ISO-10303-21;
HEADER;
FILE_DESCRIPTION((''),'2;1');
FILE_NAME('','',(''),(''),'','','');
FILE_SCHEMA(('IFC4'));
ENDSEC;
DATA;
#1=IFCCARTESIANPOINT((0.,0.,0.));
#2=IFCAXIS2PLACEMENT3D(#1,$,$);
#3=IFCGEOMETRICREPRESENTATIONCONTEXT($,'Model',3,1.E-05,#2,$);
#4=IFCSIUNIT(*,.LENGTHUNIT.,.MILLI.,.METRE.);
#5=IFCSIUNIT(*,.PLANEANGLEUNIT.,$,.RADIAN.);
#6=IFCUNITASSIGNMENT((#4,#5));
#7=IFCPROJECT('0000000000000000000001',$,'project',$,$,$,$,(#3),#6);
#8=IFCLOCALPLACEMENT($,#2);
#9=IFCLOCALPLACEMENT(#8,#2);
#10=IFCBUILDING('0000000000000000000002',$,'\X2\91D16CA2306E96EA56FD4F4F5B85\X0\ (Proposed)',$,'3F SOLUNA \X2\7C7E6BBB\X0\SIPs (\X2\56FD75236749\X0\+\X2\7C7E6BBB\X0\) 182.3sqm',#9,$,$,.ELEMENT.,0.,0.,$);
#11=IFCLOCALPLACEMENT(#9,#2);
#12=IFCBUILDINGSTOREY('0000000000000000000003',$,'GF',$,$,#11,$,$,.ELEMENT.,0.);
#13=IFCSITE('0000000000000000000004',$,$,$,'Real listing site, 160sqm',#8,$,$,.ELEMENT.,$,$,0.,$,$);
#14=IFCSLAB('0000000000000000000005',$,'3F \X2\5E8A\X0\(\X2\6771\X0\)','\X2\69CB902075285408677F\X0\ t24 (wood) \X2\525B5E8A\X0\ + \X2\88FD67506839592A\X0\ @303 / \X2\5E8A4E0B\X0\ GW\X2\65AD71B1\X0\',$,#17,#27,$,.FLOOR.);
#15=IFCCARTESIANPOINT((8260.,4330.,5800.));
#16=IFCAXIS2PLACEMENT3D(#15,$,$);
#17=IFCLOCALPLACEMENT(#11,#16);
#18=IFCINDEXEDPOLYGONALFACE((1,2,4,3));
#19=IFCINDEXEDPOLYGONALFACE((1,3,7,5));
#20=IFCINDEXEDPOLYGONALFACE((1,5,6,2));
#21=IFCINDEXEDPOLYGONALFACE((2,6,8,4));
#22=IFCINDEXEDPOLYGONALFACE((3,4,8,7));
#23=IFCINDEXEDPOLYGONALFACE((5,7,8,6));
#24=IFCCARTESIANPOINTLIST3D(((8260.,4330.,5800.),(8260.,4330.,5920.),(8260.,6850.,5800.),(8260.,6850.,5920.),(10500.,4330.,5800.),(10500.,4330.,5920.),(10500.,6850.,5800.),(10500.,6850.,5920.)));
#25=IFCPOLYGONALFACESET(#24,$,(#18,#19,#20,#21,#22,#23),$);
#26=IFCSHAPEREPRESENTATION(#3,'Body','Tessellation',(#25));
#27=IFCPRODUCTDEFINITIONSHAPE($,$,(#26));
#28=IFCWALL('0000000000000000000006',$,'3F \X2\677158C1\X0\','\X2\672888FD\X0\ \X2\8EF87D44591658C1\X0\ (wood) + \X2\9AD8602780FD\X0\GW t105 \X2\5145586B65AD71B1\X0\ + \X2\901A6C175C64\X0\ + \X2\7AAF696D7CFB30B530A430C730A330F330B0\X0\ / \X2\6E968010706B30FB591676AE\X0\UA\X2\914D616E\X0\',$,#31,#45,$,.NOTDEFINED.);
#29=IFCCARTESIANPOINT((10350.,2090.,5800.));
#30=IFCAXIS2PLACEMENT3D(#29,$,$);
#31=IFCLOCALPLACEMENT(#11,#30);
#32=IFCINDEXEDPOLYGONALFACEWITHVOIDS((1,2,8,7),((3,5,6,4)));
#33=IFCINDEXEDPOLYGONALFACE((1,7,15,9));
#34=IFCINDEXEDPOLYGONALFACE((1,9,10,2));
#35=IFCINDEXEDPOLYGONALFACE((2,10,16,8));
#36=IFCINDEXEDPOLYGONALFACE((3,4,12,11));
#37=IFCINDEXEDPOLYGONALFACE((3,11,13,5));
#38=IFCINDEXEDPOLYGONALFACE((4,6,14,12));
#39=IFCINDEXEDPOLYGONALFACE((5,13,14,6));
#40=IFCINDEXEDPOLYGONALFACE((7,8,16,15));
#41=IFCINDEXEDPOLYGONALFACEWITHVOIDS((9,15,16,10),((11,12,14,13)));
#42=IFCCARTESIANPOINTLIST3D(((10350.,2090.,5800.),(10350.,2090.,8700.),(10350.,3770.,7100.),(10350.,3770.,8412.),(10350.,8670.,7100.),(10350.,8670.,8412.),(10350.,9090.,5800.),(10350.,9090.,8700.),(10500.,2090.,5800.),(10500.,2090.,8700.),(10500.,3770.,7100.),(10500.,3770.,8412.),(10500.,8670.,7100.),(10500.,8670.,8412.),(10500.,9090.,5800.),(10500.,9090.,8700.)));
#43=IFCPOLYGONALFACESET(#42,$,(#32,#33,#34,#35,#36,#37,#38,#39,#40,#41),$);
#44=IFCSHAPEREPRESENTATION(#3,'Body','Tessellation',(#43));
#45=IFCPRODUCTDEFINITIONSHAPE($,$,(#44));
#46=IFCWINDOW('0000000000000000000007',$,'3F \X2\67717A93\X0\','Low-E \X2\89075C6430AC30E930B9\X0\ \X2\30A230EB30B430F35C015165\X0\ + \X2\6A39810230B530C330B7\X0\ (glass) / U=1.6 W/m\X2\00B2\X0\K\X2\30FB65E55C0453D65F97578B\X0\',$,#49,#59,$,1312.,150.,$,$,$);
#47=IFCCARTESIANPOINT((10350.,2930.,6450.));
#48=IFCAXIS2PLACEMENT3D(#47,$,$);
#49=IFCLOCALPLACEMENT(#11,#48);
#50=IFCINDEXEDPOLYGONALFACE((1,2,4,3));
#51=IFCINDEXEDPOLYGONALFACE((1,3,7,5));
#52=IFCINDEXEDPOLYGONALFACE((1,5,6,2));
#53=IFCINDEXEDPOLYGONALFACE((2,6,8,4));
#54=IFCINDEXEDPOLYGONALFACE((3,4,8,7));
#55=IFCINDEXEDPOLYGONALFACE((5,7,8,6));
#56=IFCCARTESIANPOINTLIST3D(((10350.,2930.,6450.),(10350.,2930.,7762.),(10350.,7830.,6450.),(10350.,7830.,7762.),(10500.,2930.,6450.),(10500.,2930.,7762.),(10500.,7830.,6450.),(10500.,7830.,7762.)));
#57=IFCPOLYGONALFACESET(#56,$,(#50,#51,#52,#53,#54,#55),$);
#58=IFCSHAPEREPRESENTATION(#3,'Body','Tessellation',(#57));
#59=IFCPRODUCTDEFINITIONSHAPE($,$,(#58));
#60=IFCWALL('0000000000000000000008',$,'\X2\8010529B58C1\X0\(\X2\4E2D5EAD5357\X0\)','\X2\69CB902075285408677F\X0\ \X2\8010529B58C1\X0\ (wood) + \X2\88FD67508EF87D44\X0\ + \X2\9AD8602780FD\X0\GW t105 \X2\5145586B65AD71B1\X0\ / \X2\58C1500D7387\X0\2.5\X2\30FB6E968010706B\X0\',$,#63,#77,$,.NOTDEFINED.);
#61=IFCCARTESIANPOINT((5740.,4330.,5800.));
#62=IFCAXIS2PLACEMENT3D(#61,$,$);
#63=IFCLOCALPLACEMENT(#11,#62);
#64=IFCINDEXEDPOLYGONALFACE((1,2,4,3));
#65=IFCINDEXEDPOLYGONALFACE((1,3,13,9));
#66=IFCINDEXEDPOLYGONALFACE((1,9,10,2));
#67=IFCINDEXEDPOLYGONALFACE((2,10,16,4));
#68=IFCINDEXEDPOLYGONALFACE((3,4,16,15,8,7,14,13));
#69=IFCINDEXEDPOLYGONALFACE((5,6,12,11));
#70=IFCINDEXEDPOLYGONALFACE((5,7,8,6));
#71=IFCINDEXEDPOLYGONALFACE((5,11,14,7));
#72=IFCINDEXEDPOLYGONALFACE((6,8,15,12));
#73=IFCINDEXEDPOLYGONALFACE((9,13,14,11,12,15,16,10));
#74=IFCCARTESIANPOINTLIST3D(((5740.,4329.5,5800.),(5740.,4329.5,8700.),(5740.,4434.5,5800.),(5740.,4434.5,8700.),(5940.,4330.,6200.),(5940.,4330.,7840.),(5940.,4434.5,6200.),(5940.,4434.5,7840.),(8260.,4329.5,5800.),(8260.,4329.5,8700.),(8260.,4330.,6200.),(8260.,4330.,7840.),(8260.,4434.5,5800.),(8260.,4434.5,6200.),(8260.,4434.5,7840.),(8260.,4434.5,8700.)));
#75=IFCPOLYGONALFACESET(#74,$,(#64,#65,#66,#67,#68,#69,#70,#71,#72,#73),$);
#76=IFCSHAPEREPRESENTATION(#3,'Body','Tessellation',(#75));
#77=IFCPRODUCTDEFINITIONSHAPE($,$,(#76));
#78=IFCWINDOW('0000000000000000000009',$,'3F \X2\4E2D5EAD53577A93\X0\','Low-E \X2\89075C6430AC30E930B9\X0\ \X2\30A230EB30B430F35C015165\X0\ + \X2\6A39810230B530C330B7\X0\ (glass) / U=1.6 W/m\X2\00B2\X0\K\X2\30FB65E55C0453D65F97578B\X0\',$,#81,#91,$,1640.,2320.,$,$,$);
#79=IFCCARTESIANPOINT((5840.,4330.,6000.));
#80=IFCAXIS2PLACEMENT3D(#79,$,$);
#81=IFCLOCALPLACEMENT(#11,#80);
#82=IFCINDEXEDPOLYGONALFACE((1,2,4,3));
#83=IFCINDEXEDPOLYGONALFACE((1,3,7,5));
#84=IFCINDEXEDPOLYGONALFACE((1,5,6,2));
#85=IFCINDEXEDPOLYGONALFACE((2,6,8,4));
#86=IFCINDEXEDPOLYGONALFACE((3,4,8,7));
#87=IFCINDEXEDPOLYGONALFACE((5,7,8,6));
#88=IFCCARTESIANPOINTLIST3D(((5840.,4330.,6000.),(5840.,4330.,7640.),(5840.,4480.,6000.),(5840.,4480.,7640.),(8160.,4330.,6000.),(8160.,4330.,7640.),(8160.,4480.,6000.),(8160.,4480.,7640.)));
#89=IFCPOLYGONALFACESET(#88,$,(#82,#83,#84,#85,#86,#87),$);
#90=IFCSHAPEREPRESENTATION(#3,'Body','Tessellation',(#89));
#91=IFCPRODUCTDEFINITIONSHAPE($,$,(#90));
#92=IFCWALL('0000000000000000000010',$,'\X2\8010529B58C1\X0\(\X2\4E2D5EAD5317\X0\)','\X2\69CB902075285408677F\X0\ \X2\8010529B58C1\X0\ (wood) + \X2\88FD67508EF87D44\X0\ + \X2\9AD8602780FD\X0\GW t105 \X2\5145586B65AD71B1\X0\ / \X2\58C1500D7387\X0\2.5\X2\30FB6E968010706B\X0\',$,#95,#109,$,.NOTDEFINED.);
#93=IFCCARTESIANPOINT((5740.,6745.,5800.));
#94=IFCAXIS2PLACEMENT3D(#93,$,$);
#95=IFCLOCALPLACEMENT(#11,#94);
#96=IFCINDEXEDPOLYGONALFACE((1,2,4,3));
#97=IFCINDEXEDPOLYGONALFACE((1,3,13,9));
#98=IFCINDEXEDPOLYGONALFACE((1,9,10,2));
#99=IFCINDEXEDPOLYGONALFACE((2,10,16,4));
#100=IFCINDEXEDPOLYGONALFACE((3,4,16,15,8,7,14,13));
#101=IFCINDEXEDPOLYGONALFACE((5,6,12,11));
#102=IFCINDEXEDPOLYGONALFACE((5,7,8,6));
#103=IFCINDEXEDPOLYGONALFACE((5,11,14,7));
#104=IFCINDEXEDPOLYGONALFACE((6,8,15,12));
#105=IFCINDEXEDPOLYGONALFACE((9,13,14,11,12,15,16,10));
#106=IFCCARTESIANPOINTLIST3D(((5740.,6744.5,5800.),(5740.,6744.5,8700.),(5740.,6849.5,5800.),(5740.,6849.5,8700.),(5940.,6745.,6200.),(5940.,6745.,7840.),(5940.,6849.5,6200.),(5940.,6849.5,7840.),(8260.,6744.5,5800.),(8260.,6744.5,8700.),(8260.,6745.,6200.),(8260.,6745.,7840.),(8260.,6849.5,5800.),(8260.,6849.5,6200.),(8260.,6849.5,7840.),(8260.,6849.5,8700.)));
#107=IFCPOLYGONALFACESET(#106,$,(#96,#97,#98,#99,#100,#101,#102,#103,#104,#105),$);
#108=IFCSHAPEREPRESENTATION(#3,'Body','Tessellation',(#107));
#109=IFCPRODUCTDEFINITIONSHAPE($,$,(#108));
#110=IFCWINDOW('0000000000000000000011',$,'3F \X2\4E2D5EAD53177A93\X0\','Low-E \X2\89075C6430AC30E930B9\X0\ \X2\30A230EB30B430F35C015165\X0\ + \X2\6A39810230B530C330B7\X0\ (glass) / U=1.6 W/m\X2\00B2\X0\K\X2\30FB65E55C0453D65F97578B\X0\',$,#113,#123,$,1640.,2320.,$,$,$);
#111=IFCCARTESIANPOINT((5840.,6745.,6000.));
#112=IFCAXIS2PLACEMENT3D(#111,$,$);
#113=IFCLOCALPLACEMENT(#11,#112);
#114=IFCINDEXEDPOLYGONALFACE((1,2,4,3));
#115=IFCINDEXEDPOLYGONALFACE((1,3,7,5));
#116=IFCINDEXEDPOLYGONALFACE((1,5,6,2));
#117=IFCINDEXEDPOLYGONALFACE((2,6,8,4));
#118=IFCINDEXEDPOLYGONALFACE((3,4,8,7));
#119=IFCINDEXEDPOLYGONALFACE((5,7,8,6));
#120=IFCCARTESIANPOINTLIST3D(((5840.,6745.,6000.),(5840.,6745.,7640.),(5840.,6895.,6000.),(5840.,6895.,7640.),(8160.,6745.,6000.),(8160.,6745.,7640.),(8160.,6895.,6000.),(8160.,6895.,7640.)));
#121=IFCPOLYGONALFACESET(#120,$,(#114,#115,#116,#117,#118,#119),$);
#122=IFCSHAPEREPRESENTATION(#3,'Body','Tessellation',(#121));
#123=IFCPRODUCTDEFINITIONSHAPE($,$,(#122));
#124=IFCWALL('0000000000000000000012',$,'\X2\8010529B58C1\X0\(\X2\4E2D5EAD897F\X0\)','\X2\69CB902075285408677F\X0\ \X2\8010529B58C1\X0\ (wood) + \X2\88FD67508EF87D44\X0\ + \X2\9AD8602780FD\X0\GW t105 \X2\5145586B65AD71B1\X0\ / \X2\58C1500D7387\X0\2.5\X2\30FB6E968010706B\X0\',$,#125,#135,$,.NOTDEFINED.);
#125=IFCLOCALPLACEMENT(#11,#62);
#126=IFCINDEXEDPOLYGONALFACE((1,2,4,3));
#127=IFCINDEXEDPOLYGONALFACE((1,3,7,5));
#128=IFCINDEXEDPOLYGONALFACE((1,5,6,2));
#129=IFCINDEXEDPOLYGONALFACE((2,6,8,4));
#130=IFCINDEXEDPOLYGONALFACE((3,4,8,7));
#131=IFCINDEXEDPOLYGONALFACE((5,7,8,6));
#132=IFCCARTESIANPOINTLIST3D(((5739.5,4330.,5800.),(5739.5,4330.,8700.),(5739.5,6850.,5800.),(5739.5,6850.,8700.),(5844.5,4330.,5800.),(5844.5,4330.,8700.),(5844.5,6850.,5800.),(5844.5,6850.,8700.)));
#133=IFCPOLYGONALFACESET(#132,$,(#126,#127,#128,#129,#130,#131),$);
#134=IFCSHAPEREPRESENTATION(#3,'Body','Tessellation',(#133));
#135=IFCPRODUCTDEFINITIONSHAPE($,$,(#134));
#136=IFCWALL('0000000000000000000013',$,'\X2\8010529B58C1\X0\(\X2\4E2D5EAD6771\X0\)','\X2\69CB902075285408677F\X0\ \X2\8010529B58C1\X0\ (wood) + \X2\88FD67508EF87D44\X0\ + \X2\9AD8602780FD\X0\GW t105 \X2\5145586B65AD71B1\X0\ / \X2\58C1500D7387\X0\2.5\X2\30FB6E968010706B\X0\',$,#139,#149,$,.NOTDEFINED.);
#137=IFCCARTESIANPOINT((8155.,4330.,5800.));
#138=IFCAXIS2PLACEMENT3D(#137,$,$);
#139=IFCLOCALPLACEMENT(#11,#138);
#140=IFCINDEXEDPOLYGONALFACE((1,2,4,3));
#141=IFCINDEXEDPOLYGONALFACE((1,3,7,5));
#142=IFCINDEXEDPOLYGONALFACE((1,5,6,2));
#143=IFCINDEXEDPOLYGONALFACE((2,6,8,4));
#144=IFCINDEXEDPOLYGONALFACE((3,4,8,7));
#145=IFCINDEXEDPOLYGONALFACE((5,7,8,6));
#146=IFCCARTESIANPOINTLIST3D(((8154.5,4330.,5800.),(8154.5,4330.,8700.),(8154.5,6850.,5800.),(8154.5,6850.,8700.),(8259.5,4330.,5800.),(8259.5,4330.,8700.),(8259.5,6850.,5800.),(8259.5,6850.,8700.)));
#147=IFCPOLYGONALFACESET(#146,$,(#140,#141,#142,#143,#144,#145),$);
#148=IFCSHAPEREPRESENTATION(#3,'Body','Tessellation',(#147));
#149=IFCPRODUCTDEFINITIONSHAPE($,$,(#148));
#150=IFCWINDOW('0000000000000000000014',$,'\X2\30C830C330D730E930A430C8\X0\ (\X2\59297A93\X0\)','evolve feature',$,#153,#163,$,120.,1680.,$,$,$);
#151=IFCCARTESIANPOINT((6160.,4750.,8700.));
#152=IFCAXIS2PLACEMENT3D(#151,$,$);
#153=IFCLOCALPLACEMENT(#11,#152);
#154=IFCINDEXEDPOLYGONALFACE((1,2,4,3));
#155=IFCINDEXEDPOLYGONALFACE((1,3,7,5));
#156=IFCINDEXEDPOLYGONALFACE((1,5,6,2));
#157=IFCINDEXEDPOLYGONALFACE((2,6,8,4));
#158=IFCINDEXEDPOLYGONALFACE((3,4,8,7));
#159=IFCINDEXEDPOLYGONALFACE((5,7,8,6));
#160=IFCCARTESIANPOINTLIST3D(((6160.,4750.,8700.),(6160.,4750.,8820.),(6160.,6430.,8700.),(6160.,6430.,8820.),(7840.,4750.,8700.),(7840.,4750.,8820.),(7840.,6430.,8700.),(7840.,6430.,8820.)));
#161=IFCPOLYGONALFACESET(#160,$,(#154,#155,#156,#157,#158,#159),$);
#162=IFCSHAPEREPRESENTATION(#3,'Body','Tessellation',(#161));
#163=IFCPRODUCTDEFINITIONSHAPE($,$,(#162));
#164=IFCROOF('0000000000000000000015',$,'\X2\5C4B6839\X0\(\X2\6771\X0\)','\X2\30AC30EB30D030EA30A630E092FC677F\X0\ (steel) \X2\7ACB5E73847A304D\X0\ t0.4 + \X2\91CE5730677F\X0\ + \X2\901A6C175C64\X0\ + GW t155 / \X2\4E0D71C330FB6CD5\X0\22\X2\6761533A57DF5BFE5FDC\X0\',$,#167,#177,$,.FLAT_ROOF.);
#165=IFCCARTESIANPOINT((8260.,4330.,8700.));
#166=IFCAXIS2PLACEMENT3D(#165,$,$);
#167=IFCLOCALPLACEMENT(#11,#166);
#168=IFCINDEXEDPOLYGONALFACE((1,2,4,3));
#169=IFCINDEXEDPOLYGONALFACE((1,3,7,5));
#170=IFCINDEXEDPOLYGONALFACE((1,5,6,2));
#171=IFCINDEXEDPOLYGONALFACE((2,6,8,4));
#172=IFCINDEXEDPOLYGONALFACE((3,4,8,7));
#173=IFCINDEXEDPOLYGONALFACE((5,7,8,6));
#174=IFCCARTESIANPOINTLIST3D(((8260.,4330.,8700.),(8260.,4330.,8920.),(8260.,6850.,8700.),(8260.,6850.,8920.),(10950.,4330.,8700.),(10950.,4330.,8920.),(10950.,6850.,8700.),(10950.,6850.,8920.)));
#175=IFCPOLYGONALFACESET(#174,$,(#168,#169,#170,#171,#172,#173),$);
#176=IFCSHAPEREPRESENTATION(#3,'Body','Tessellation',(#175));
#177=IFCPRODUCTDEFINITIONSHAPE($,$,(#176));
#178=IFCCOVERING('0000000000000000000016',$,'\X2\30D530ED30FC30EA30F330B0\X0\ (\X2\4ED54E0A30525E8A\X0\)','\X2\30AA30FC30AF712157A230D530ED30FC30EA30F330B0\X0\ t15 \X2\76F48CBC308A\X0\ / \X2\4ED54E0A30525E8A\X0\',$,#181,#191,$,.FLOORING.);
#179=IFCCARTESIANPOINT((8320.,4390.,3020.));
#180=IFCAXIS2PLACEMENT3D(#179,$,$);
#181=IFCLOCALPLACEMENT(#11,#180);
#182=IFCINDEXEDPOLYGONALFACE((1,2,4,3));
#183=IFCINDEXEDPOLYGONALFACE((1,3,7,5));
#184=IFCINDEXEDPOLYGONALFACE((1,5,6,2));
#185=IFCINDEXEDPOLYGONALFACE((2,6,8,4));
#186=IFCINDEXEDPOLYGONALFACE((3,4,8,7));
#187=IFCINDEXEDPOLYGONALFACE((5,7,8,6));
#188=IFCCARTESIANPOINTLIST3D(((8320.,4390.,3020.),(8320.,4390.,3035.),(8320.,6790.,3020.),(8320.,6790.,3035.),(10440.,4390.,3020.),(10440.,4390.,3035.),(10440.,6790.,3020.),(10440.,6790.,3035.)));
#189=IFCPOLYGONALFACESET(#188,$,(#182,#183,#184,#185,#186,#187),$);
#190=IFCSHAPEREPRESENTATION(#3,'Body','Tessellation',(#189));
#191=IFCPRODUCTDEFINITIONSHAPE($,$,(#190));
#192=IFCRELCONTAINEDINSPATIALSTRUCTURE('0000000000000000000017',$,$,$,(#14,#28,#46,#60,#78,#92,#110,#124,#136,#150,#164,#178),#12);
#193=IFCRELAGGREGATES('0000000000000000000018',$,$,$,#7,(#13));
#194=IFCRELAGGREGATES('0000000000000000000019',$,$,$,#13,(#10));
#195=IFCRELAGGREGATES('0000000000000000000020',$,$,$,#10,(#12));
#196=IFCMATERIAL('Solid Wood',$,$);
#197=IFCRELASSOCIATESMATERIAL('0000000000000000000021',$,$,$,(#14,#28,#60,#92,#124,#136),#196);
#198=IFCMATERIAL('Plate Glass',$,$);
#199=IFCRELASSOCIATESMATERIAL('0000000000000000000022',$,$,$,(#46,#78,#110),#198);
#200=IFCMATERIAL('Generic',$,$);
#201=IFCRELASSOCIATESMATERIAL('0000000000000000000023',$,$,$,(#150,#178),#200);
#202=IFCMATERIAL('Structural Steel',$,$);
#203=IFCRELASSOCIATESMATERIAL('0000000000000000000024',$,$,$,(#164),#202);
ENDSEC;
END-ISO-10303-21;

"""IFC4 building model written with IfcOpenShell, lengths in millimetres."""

from ifc_helpers import new_model, si_unit, frame, frame_2d, origin, place, context, project, spatial, rectangle, extrude, material, element, fill, save


model = new_model("IFC4")

# Units and contexts
model_context = context("Model", 3, precision=1e-05, world=origin())
ifc_project = project(units=[si_unit("LENGTHUNIT", "METRE", prefix="MILLI"), si_unit("PLANEANGLEUNIT", "RADIAN")], contexts=[model_context])

# Site, building, storey
site_placement = place(None, origin())
site = spatial("IfcSite", under=ifc_project, at=site_placement, ObjectType="Real listing site, 160sqm", CompositionType="ELEMENT", RefElevation=0.0)
building_placement = place(site_placement, origin())
building = spatial("IfcBuilding", under=site, at=building_placement, Name="金沢の雪国住宅 (Proposed)", ObjectType="3F SOLUNA 籾殻SIPs (国産杉+籾殻) 182.3sqm", CompositionType="ELEMENT", ElevationOfRefHeight=0.0, ElevationOfTerrain=0.0)
storey_placement = place(building_placement, origin())
storey = spatial("IfcBuildingStorey", under=building, at=storey_placement, Name="GF", CompositionType="ELEMENT", Elevation=0.0)

# Slab
ifc_material_1 = material(Name="Solid Wood")
slab_placement = place(storey_placement, frame((8260.0, 4330.0, 5800.0)))
element("IfcSlab", 1, at=slab_placement, inside=storey, material=ifc_material_1, Name="3F 床(東)", Description="構造用合板 t24 (wood) 剛床 + 製材根太 @303 / 床下 GW断熱", PredefinedType="FLOOR", context=model_context, shape_type="SweptSolid", body=[
    extrude(rectangle(XDim=2240.0, YDim=2520.0, at=frame_2d((1120.0, 1260.0))), frame((8260.0, 4330.0, 5800.0)), (0.0, 0.0, 1.0), 120.0),
])

# Walls, openings, windows
wall_1_placement = place(storey_placement, frame((10350.0, 2090.0, 5800.0)))
wall_1 = element("IfcWall", 2, at=wall_1_placement, inside=storey, material=ifc_material_1, Name="3F 東壁", Description="木製 軸組外壁 (wood) + 高性能GW t105 充填断熱 + 通気層 + 窯業系サイディング / 準耐火・外皮UA配慮", PredefinedType="NOTDEFINED", context=model_context, shape_type="SweptSolid", body=[
    extrude(rectangle(XDim=150.0, YDim=7000.0, at=frame_2d((75.0, 3500.0))), frame((10350.0, 2090.0, 5800.0)), (0.0, 0.0, 1.0), 2900.0),
])
opening_1_placement = place(storey_placement, frame((10350.0, 2930.0, 6450.0)))
opening_1 = element("IfcOpeningElement", 3, at=opening_1_placement, cuts=wall_1, PredefinedType="NOTDEFINED", context=model_context, shape_type="SweptSolid", body=[
    extrude(rectangle(XDim=150.0, YDim=4900.0, at=frame_2d((75.0, 2450.0))), frame((10350.0, 2930.0, 6450.0)), (0.0, 0.0, 1.0), 1312.0),
])
ifc_material_2 = material(Name="Plate Glass")
window_1_placement = place(storey_placement, frame((10350.0, 2930.0, 6450.0)))
window_1 = element("IfcWindow", 4, at=window_1_placement, inside=storey, material=ifc_material_2, Name="3F 東窓", Description="Low-E 複層ガラス アルゴン封入 + 樹脂サッシ (glass) / U=1.6 W/m²K・日射取得型", OverallHeight=1312.0, OverallWidth=150.0, context=model_context, shape_type="SweptSolid", body=[
    extrude(rectangle(XDim=150.0, YDim=4900.0, at=frame_2d((75.0, 2450.0))), frame((10350.0, 2930.0, 6450.0)), (0.0, 0.0, 1.0), 1312.0),
])
fill(opening_1, window_1)
wall_2_placement = place(storey_placement, frame((5740.0, 4330.0, 5800.0)))
wall_2 = element("IfcWall", 5, at=wall_2_placement, inside=storey, material=ifc_material_1, Name="耐力壁(中庭南)", Description="構造用合板 耐力壁 (wood) + 製材軸組 + 高性能GW t105 充填断熱 / 壁倍率2.5・準耐火", PredefinedType="NOTDEFINED", context=model_context, shape_type="SweptSolid", body=[
    extrude(rectangle(XDim=2520.0, YDim=105.0, at=frame_2d((1260.0, 52.0))), frame((5740.0, 4330.0, 5800.0)), (0.0, 0.0, 1.0), 2900.0),
])
opening_2_placement = place(storey_placement, frame((5840.0, 4330.0, 6000.0)))
opening_2 = element("IfcOpeningElement", 6, at=opening_2_placement, cuts=wall_2, PredefinedType="NOTDEFINED", context=model_context, shape_type="SweptSolid", body=[
    extrude(rectangle(XDim=2320.0, YDim=150.0, at=frame_2d((1160.0, 75.0))), frame((5840.0, 4330.0, 6000.0)), (0.0, 0.0, 1.0), 1640.0),
])
window_2_placement = place(storey_placement, frame((5840.0, 4330.0, 6000.0)))
window_2 = element("IfcWindow", 7, at=window_2_placement, inside=storey, material=ifc_material_2, Name="3F 中庭南窓", Description="Low-E 複層ガラス アルゴン封入 + 樹脂サッシ (glass) / U=1.6 W/m²K・日射取得型", OverallHeight=1640.0, OverallWidth=2320.0, context=model_context, shape_type="SweptSolid", body=[
    extrude(rectangle(XDim=2320.0, YDim=150.0, at=frame_2d((1160.0, 75.0))), frame((5840.0, 4330.0, 6000.0)), (0.0, 0.0, 1.0), 1640.0),
])
fill(opening_2, window_2)
wall_3_placement = place(storey_placement, frame((5740.0, 6745.0, 5800.0)))
wall_3 = element("IfcWall", 8, at=wall_3_placement, inside=storey, material=ifc_material_1, Name="耐力壁(中庭北)", Description="構造用合板 耐力壁 (wood) + 製材軸組 + 高性能GW t105 充填断熱 / 壁倍率2.5・準耐火", PredefinedType="NOTDEFINED", context=model_context, shape_type="SweptSolid", body=[
    extrude(rectangle(XDim=2520.0, YDim=105.0, at=frame_2d((1260.0, 52.0))), frame((5740.0, 6745.0, 5800.0)), (0.0, 0.0, 1.0), 2900.0),
])
opening_3_placement = place(storey_placement, frame((5840.0, 6745.0, 6000.0)))
opening_3 = element("IfcOpeningElement", 9, at=opening_3_placement, cuts=wall_3, PredefinedType="NOTDEFINED", context=model_context, shape_type="SweptSolid", body=[
    extrude(rectangle(XDim=2320.0, YDim=150.0, at=frame_2d((1160.0, 75.0))), frame((5840.0, 6745.0, 6000.0)), (0.0, 0.0, 1.0), 1640.0),
])
window_3_placement = place(storey_placement, frame((5840.0, 6745.0, 6000.0)))
window_3 = element("IfcWindow", 10, at=window_3_placement, inside=storey, material=ifc_material_2, Name="3F 中庭北窓", Description="Low-E 複層ガラス アルゴン封入 + 樹脂サッシ (glass) / U=1.6 W/m²K・日射取得型", OverallHeight=1640.0, OverallWidth=2320.0, context=model_context, shape_type="SweptSolid", body=[
    extrude(rectangle(XDim=2320.0, YDim=150.0, at=frame_2d((1160.0, 75.0))), frame((5840.0, 6745.0, 6000.0)), (0.0, 0.0, 1.0), 1640.0),
])
fill(opening_3, window_3)

# Walls
wall_4_placement = place(storey_placement, frame((5740.0, 4330.0, 5800.0)))
element("IfcWall", 11, at=wall_4_placement, inside=storey, material=ifc_material_1, Name="耐力壁(中庭西)", Description="構造用合板 耐力壁 (wood) + 製材軸組 + 高性能GW t105 充填断熱 / 壁倍率2.5・準耐火", PredefinedType="NOTDEFINED", context=model_context, shape_type="SweptSolid", body=[
    extrude(rectangle(XDim=105.0, YDim=2520.0, at=frame_2d((52.0, 1260.0))), frame((5740.0, 4330.0, 5800.0)), (0.0, 0.0, 1.0), 2900.0),
])
wall_5_placement = place(storey_placement, frame((8155.0, 4330.0, 5800.0)))
element("IfcWall", 12, at=wall_5_placement, inside=storey, material=ifc_material_1, Name="耐力壁(中庭東)", Description="構造用合板 耐力壁 (wood) + 製材軸組 + 高性能GW t105 充填断熱 / 壁倍率2.5・準耐火", PredefinedType="NOTDEFINED", context=model_context, shape_type="SweptSolid", body=[
    extrude(rectangle(XDim=105.0, YDim=2520.0, at=frame_2d((52.0, 1260.0))), frame((8155.0, 4330.0, 5800.0)), (0.0, 0.0, 1.0), 2900.0),
])

# Window
ifc_material_3 = material(Name="Generic")
window_4_placement = place(storey_placement, frame((6160.0, 4750.0, 8700.0)))
element("IfcWindow", 13, at=window_4_placement, inside=storey, material=ifc_material_3, Name="トップライト (天窓)", Description="evolve feature", OverallHeight=120.0, OverallWidth=1680.0, context=model_context, shape_type="SweptSolid", body=[
    extrude(rectangle(XDim=1680.0, YDim=1680.0, at=frame_2d((840.0, 840.0))), frame((6160.0, 4750.0, 8700.0)), (0.0, 0.0, 1.0), 120.0),
])

# Roof
ifc_material_4 = material(Name="Structural Steel")
for number, where, name in (
    (14, (8260.0, 4330.0, 8700.0), "屋根(東)"),
):
    element("IfcRoof", number, at=place(storey_placement, frame(where)), inside=storey, material=ifc_material_4, Name=name, Description="ガルバリウム鋼板 (steel) 立平葺き t0.4 + 野地板 + 通気層 + GW t155 / 不燃・法22条区域対応", PredefinedType="FLAT_ROOF", context=model_context, shape_type="SweptSolid", body=[
        extrude(rectangle(XDim=2690.0, YDim=2520.0, at=frame_2d((1345.0, 1260.0))), frame((8260.0, 4330.0, 8700.0)), (0.0, 0.0, 1.0), 220.0),
    ])

# Covering
covering_1_placement = place(storey_placement, frame((8320.0, 4390.0, 3020.0)))
element("IfcCovering", 15, at=covering_1_placement, inside=storey, material=ifc_material_3, Name="フローリング (仕上げ床)", Description="オーク無垢フローリング t15 直貼り / 仕上げ床", PredefinedType="FLOORING", context=model_context, shape_type="SweptSolid", body=[
    extrude(rectangle(XDim=2120.0, YDim=2400.0, at=frame_2d((1060.0, 1200.0))), frame((8320.0, 4390.0, 3020.0)), (0.0, 0.0, 1.0), 15.0),
])

save(model, "model.ifc")
